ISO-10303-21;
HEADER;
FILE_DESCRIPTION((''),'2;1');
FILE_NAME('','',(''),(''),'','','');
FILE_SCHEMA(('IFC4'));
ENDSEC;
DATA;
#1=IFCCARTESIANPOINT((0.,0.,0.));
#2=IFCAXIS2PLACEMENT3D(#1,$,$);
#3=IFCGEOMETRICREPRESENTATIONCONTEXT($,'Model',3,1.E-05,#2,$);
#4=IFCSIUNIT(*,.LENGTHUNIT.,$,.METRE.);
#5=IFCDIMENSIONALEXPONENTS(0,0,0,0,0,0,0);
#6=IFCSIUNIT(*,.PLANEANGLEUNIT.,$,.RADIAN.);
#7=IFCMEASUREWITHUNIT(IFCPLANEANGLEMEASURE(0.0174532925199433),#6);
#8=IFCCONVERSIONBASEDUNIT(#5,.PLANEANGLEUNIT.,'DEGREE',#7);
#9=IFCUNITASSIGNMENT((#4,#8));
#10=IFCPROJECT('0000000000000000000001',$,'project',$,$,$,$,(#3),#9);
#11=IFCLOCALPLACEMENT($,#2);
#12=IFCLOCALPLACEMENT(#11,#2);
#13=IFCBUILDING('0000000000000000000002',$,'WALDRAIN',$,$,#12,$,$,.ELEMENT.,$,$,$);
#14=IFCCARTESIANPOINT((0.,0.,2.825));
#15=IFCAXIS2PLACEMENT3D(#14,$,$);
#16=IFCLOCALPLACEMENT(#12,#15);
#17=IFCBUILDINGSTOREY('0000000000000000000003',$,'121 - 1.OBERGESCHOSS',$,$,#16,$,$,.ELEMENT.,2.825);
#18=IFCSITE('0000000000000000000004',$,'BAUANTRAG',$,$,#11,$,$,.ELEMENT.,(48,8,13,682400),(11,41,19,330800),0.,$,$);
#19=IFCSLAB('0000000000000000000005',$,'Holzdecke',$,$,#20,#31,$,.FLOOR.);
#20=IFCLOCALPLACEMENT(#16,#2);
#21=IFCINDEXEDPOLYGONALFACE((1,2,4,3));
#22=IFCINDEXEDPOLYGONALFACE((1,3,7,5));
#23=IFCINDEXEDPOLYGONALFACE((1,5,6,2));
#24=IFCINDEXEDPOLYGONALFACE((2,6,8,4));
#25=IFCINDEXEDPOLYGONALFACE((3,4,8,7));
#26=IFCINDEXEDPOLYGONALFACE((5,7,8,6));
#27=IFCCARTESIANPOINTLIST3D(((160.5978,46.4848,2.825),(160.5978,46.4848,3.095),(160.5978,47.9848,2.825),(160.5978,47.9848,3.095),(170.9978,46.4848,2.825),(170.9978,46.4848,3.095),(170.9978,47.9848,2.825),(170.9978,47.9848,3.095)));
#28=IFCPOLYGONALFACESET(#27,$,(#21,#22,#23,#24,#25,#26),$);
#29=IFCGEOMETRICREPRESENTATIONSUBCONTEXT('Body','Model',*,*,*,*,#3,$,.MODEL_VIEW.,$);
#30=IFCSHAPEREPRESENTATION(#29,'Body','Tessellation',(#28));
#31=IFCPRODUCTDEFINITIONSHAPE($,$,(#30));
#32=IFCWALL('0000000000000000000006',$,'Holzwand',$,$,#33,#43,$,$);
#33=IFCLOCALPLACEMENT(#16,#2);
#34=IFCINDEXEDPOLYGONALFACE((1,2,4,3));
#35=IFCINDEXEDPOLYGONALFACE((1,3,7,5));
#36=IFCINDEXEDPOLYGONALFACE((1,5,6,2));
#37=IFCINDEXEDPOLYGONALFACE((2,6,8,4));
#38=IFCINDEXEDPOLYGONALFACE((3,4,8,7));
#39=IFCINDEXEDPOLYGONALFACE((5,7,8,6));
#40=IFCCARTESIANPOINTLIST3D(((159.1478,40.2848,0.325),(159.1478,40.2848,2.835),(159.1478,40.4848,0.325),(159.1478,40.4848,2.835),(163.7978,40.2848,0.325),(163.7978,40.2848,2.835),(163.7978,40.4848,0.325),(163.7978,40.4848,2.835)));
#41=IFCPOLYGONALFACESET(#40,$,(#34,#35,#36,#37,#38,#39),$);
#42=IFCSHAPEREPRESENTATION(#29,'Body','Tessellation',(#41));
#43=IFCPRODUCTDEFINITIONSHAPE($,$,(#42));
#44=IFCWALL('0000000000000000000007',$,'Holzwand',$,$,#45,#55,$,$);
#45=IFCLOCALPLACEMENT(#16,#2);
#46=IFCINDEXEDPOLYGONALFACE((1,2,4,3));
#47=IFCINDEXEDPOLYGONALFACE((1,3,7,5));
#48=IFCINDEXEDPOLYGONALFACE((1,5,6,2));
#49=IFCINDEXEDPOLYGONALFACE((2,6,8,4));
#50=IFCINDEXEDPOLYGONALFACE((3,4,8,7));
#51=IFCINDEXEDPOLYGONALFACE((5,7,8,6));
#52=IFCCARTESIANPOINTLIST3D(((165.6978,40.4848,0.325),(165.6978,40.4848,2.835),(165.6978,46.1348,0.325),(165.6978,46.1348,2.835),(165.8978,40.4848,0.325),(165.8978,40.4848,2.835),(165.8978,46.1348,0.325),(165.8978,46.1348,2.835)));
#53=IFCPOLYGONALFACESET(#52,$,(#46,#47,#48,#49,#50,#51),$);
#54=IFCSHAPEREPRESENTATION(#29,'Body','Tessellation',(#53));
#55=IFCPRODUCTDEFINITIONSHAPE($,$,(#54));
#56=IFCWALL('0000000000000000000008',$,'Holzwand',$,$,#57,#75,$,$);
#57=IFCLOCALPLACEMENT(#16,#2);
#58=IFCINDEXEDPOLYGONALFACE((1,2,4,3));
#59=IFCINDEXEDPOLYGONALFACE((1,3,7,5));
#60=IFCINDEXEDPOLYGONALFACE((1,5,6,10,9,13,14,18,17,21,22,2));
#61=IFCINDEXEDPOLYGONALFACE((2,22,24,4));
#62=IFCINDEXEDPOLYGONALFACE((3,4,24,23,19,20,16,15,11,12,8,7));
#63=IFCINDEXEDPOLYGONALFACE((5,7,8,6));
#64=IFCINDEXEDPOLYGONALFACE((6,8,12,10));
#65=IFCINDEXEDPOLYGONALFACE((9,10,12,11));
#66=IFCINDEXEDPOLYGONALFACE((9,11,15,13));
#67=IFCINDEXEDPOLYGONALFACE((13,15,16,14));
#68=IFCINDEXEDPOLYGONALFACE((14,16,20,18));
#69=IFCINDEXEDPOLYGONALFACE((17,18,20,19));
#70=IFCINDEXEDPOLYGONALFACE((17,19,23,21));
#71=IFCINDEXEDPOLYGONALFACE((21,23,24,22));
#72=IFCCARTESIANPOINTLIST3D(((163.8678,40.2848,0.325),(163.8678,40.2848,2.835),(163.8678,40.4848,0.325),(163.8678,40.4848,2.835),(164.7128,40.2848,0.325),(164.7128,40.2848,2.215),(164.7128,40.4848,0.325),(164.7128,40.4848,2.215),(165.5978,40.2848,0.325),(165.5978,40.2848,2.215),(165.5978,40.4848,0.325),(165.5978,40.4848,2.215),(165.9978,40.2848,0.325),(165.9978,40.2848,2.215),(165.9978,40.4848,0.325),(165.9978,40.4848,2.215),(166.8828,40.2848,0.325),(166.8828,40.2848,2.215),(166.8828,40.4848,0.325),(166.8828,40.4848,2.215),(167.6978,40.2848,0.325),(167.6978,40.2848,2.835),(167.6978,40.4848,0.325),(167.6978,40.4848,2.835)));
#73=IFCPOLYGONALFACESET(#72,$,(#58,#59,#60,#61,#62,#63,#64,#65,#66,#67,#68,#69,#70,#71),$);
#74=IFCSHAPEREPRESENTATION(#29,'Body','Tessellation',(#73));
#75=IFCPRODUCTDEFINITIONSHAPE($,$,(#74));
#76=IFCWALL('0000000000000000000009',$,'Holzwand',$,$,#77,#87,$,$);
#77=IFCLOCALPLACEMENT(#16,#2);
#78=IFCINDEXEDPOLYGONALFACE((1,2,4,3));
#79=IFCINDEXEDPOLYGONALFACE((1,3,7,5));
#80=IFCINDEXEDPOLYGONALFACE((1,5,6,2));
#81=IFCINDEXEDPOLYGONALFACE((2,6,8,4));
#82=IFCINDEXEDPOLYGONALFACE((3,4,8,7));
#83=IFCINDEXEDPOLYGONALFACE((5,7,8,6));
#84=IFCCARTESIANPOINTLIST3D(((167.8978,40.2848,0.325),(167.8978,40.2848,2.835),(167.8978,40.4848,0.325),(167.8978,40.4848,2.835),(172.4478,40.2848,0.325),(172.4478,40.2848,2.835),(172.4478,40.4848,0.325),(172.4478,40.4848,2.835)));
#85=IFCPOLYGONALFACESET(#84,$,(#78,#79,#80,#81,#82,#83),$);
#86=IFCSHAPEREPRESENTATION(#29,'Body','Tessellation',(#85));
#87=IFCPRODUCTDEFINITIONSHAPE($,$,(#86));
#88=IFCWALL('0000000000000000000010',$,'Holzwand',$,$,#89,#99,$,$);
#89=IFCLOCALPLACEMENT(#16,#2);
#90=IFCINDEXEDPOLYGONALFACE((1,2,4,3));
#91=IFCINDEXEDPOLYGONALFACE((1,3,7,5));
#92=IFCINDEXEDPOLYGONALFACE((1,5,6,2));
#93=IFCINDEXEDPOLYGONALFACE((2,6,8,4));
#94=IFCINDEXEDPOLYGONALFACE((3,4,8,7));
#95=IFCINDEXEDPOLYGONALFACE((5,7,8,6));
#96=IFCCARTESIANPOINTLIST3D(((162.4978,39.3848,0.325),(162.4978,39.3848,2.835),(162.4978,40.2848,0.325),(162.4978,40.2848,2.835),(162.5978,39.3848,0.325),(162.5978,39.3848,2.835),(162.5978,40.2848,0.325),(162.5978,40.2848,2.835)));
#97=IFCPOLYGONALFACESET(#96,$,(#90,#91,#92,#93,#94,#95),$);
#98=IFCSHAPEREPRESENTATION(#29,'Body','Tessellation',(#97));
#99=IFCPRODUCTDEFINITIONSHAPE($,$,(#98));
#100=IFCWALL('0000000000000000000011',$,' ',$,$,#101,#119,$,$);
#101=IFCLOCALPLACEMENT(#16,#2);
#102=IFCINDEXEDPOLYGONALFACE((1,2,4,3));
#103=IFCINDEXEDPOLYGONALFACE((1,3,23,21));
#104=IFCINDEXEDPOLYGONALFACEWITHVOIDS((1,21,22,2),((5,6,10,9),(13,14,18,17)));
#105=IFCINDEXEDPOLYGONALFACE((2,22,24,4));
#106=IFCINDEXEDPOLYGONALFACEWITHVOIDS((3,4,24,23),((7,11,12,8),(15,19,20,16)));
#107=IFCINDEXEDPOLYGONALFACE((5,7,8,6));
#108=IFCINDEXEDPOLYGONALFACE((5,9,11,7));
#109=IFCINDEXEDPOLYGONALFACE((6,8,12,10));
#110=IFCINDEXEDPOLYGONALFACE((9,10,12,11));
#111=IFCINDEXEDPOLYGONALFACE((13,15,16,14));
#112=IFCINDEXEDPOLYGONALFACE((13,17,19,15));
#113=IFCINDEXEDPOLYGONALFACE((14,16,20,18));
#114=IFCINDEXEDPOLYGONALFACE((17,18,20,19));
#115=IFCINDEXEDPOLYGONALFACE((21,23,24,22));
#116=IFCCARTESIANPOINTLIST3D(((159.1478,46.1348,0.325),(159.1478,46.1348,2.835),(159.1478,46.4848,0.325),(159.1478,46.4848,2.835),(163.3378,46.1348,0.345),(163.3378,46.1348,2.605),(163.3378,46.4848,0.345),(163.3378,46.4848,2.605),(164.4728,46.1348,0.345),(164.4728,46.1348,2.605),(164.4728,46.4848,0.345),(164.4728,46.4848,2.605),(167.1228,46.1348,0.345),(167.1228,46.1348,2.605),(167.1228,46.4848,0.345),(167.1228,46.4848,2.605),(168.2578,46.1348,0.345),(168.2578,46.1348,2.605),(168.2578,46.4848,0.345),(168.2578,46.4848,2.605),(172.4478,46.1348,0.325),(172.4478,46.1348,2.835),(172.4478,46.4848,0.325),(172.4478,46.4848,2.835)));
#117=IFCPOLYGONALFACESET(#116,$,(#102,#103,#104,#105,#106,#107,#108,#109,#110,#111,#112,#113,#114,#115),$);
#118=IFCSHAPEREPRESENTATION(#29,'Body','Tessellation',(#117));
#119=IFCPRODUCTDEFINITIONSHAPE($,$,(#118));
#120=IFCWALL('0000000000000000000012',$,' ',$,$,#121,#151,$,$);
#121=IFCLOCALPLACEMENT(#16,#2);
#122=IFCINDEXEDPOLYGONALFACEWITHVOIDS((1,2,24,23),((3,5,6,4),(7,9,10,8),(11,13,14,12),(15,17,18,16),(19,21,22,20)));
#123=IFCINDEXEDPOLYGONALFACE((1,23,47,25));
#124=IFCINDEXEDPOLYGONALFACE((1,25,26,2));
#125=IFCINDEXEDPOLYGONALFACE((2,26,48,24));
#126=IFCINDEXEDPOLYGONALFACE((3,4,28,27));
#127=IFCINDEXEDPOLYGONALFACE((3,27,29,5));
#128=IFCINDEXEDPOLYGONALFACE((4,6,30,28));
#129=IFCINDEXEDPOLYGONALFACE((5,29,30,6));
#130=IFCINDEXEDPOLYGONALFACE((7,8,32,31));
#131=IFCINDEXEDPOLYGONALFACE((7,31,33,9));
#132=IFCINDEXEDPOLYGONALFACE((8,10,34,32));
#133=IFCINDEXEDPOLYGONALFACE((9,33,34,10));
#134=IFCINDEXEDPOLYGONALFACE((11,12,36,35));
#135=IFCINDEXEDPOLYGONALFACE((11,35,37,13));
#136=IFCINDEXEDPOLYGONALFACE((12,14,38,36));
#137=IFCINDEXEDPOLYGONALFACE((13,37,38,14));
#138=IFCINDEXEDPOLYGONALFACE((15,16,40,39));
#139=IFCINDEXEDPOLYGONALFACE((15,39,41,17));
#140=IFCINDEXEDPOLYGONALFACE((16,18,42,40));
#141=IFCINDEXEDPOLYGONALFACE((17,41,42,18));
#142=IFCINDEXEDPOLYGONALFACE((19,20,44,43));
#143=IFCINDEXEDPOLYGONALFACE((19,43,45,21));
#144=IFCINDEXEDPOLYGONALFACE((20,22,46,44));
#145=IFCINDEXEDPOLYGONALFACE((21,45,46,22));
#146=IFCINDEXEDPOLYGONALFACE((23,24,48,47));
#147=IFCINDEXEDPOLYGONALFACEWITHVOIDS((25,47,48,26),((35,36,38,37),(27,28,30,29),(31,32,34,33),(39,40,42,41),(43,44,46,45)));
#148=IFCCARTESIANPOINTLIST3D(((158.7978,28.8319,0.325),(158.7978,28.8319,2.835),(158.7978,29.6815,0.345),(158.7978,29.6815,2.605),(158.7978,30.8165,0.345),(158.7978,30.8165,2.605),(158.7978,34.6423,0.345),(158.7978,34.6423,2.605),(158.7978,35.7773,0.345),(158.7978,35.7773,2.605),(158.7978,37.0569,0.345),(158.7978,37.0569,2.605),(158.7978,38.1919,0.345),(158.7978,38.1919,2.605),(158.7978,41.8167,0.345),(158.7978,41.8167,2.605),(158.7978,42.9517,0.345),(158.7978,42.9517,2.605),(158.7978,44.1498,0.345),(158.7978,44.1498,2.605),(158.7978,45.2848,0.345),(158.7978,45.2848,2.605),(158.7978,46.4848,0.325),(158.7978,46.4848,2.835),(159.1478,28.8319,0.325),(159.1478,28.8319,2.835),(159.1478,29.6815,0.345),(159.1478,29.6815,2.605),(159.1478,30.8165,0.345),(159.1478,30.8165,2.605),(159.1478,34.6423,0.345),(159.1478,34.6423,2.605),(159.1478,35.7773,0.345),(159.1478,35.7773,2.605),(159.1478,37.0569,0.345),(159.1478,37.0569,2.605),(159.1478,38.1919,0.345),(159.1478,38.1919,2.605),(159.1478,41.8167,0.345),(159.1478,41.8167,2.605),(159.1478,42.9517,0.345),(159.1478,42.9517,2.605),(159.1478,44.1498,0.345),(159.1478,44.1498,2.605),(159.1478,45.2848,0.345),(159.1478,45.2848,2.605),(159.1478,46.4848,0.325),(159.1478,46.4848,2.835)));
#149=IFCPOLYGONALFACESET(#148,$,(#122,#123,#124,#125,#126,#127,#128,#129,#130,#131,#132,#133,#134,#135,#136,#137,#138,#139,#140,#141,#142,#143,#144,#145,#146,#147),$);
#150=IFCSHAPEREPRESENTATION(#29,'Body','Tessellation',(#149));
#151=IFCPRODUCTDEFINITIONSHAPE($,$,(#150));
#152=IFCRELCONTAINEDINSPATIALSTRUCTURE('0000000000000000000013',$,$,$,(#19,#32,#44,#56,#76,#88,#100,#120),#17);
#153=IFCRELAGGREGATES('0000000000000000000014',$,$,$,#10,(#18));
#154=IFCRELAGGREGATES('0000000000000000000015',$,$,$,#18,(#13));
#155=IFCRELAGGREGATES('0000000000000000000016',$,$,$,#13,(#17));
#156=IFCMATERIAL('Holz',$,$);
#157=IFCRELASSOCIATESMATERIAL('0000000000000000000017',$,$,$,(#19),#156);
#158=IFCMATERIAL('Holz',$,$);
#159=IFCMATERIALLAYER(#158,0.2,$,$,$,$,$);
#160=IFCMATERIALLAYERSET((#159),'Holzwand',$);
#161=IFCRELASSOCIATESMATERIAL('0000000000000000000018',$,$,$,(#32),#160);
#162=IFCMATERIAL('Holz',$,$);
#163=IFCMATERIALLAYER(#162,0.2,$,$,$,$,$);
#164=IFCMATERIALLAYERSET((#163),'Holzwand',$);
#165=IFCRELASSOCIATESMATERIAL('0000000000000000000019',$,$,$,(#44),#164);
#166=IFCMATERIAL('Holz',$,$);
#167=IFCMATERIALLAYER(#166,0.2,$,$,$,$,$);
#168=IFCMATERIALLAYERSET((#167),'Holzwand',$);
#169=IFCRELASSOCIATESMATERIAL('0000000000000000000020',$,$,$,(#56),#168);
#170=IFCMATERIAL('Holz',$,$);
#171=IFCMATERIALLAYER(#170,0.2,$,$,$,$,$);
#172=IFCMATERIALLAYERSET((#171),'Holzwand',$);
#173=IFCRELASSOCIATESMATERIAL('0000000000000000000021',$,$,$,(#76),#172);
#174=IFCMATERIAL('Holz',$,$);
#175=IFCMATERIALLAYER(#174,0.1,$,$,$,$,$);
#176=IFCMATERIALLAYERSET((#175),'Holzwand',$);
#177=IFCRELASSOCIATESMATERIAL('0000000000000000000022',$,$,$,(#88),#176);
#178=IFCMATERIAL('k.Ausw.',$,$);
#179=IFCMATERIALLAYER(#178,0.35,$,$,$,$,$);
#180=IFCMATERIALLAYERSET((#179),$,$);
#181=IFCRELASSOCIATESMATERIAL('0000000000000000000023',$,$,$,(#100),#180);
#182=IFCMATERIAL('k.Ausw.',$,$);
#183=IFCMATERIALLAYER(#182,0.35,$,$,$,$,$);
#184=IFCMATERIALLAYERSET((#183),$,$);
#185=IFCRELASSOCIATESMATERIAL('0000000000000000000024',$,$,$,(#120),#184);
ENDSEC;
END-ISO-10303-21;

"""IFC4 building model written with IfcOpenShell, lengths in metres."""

from ifc_helpers import new_model, entity, si_unit, converted_unit, frame, frame_2d, origin, origin_with_axes, place, context, subcontext, project, spatial, polyline, rectangle, outline, extrude, material, layer, layer_set, layer_usage, element, save


model = new_model("IFC4")

# Units and contexts
model_context = context("Model", 3, precision=1e-05, world=origin())
body_context = subcontext(model_context, "Body", "Model", "MODEL_VIEW")
ifc_project = project(units=[si_unit("LENGTHUNIT", "METRE"), converted_unit("PLANEANGLEUNIT", "DEGREE", entity("IfcPlaneAngleMeasure", 0.0174532925199433), si_unit("PLANEANGLEUNIT", "RADIAN"), dimensions=[0, 0, 0, 0, 0, 0, 0])], contexts=[model_context])

# Site, building, storey
site_placement = place(None, origin())
site = spatial("IfcSite", under=ifc_project, at=site_placement, Name="BAUANTRAG", CompositionType="ELEMENT", RefLatitude=(48, 8, 13, 682400), RefLongitude=(11, 41, 19, 330800), RefElevation=0.0)
building_placement = place(site_placement, origin())
building = spatial("IfcBuilding", under=site, at=building_placement, Name="WALDRAIN", CompositionType="ELEMENT")
storey_placement = place(building_placement, frame((0.0, 0.0, 2.825)))
storey = spatial("IfcBuildingStorey", under=building, at=storey_placement, Name="121 - 1.OBERGESCHOSS", CompositionType="ELEMENT", Elevation=2.825)

# Slab
ifc_material_1 = material(Name="Holz")
slab_placement = place(storey_placement, frame((160.5978, 46.4848, 2.825)))
element("IfcSlab", 1, at=slab_placement, inside=storey, material=ifc_material_1, Name="Holzdecke", PredefinedType="FLOOR", context=body_context, shape_type="SweptSolid", body=[
    extrude(rectangle(XDim=10.4, YDim=1.5, at=frame_2d((5.2, 0.75), x_axis=(1.0, 0.0))), origin_with_axes(), (0.0, 0.0, 1.0), 0.27),
])

# Walls
ifc_material_2 = material(Name="Holz")
ifc_layer_1 = layer(ifc_material_2, 0.2)
ifc_layer_set_1 = layer_set([ifc_layer_1], Name="Holzwand")
ifc_layer_usage_1 = layer_usage(ifc_layer_set_1, "AXIS2", "POSITIVE", 0.0)
wall_1_placement = place(storey_placement, frame((163.7978, 40.4848, 0.325), z_axis=(0.0, 0.0, 1.0), x_axis=(-1.0, 0.0, 0.0)))
element("IfcWall", 2, at=wall_1_placement, inside=storey, material=ifc_layer_usage_1, Name="Holzwand", context=body_context, shape_type="SweptSolid", body=[
    extrude(rectangle(XDim=4.65, YDim=0.2, at=frame_2d((2.325, 0.1), x_axis=(1.0, 0.0))), origin_with_axes(), (0.0, 0.0, 1.0), 2.51),
])
ifc_material_3 = material(Name="Holz")
ifc_layer_2 = layer(ifc_material_3, 0.2)
ifc_layer_set_2 = layer_set([ifc_layer_2], Name="Holzwand")
ifc_layer_usage_2 = layer_usage(ifc_layer_set_2, "AXIS2", "POSITIVE", 0.0)
wall_2_placement = place(storey_placement, frame((165.6978, 46.1348, 0.325), z_axis=(0.0, 0.0, 1.0), x_axis=(0.0, -1.0, 0.0)))
element("IfcWall", 3, at=wall_2_placement, inside=storey, material=ifc_layer_usage_2, Name="Holzwand", context=body_context, shape_type="SweptSolid", body=[
    extrude(rectangle(XDim=5.65, YDim=0.2, at=frame_2d((2.825, 0.1), x_axis=(1.0, 0.0))), origin_with_axes(), (0.0, 0.0, 1.0), 2.51),
])

# Wall, openings
ifc_material_4 = material(Name="Holz")
ifc_layer_3 = layer(ifc_material_4, 0.2)
ifc_layer_set_3 = layer_set([ifc_layer_3], Name="Holzwand")
ifc_layer_usage_3 = layer_usage(ifc_layer_set_3, "AXIS2", "POSITIVE", 0.0)
wall_3_placement = place(storey_placement, frame((167.6978, 40.4848, 0.325), z_axis=(0.0, 0.0, 1.0), x_axis=(-1.0, 0.0, 0.0)))
wall_3 = element("IfcWall", 4, at=wall_3_placement, inside=storey, material=ifc_layer_usage_3, Name="Holzwand", context=body_context, shape_type="SweptSolid", body=[
    extrude(rectangle(XDim=3.83, YDim=0.2, at=frame_2d((1.915, 0.1), x_axis=(1.0, 0.0))), origin_with_axes(), (0.0, 0.0, 1.0), 2.51),
])
opening_1_placement = place(wall_3_placement, frame((0.815, 0.0, -0.12), z_axis=(0.0, 1.0, 0.0), x_axis=(0.0, 0.0, 1.0)))
element("IfcOpeningElement", 5, at=opening_1_placement, cuts=wall_3, ObjectType="Opening", context=body_context, shape_type="SweptSolid", body=[
    extrude(outline(polyline([(0.0, 0.885), (2.01, 0.885), (2.01, 0.0), (0.0, 0.0), (0.0, 0.885)])), origin_with_axes(), (0.0, 0.0, 1.0), 0.2),
])
opening_2_placement = place(wall_3_placement, frame((2.1, 0.0, -0.12), z_axis=(0.0, 1.0, 0.0), x_axis=(0.0, 0.0, 1.0)))
element("IfcOpeningElement", 6, at=opening_2_placement, cuts=wall_3, ObjectType="Opening", context=body_context, shape_type="SweptSolid", body=[
    extrude(outline(polyline([(0.0, 0.885), (2.01, 0.885), (2.01, 0.0), (0.0, 0.0), (0.0, 0.885)])), origin_with_axes(), (0.0, 0.0, 1.0), 0.2),
])

# Walls
ifc_material_5 = material(Name="Holz")
ifc_layer_4 = layer(ifc_material_5, 0.2)
ifc_layer_set_4 = layer_set([ifc_layer_4], Name="Holzwand")
ifc_layer_usage_4 = layer_usage(ifc_layer_set_4, "AXIS2", "POSITIVE", 0.0)
wall_4_placement = place(storey_placement, frame((172.4478, 40.4848, 0.325), z_axis=(0.0, 0.0, 1.0), x_axis=(-1.0, 0.0, 0.0)))
element("IfcWall", 7, at=wall_4_placement, inside=storey, material=ifc_layer_usage_4, Name="Holzwand", context=body_context, shape_type="SweptSolid", body=[
    extrude(rectangle(XDim=4.55, YDim=0.2, at=frame_2d((2.275, 0.1), x_axis=(1.0, 0.0))), origin_with_axes(), (0.0, 0.0, 1.0), 2.51),
])
ifc_material_6 = material(Name="Holz")
ifc_layer_5 = layer(ifc_material_6, 0.1)
ifc_layer_set_5 = layer_set([ifc_layer_5], Name="Holzwand")
ifc_layer_usage_5 = layer_usage(ifc_layer_set_5, "AXIS2", "POSITIVE", 0.0)
wall_5_placement = place(storey_placement, frame((162.4978, 40.2848, 0.325), z_axis=(0.0, 0.0, 1.0), x_axis=(0.0, -1.0, 0.0)))
element("IfcWall", 8, at=wall_5_placement, inside=storey, material=ifc_layer_usage_5, Name="Holzwand", context=body_context, shape_type="SweptSolid", body=[
    extrude(rectangle(XDim=0.9, YDim=0.1, at=frame_2d((0.45, 0.05), x_axis=(1.0, 0.0))), origin_with_axes(), (0.0, 0.0, 1.0), 2.51),
])

# Walls, openings
ifc_material_7 = material(Name="k.Ausw.")
ifc_layer_6 = layer(ifc_material_7, 0.35)
ifc_layer_set_6 = layer_set([ifc_layer_6])
ifc_layer_usage_6 = layer_usage(ifc_layer_set_6, "AXIS2", "POSITIVE", 0.0)
wall_6_placement = place(storey_placement, frame((172.4478, 46.4848, 0.325), z_axis=(0.0, 0.0, 1.0), x_axis=(-1.0, 0.0, 0.0)))
wall_6 = element("IfcWall", 9, at=wall_6_placement, inside=storey, material=ifc_layer_usage_6, Name=" ", context=body_context, shape_type="SweptSolid", body=[
    extrude(rectangle(XDim=13.3, YDim=0.35, at=frame_2d((6.65, 0.175), x_axis=(1.0, 0.0))), origin_with_axes(), (0.0, 0.0, 1.0), 2.51),
])
opening_3_placement = place(wall_6_placement, frame((9.11, 0.35, 0.02), z_axis=(0.0, -1.0, 0.0), x_axis=(0.0, 0.0, 1.0)))
element("IfcOpeningElement", 10, at=opening_3_placement, cuts=wall_6, ObjectType="Opening", context=body_context, shape_type="SweptSolid", body=[
    extrude(outline(polyline([(0.0, 1.135), (2.26, 1.135), (2.26, 0.0), (0.0, 0.0), (0.0, 1.135)])), origin_with_axes(), (0.0, 0.0, 1.0), 0.35),
])
opening_4_placement = place(wall_6_placement, frame((5.325, 0.35, 0.02), z_axis=(0.0, -1.0, 0.0), x_axis=(0.0, 0.0, 1.0)))
element("IfcOpeningElement", 11, at=opening_4_placement, cuts=wall_6, ObjectType="Opening", context=body_context, shape_type="SweptSolid", body=[
    extrude(outline(polyline([(0.0, 1.135), (2.26, 1.135), (2.26, 0.0), (0.0, 0.0), (0.0, 1.135)])), origin_with_axes(), (0.0, 0.0, 1.0), 0.35),
])
ifc_material_8 = material(Name="k.Ausw.")
ifc_layer_7 = layer(ifc_material_8, 0.35)
ifc_layer_set_7 = layer_set([ifc_layer_7])
ifc_layer_usage_7 = layer_usage(ifc_layer_set_7, "AXIS2", "POSITIVE", 0.0)
wall_7_placement = place(storey_placement, frame((158.7978, 46.4848, 0.325), z_axis=(0.0, 0.0, 1.0), x_axis=(0.0, -1.0, 0.0)))
wall_7 = element("IfcWall", 12, at=wall_7_placement, inside=storey, material=ifc_layer_usage_7, Name=" ", context=body_context, shape_type="SweptSolid", body=[
    extrude(rectangle(XDim=17.6529, YDim=0.35, at=frame_2d((8.8264, 0.175), x_axis=(1.0, 0.0))), origin_with_axes(), (0.0, 0.0, 1.0), 2.51),
])
opening_5_placement = place(wall_7_placement, frame((11.8425, 0.35, 0.02), z_axis=(0.0, -1.0, 0.0), x_axis=(0.0, 0.0, 1.0)))
element("IfcOpeningElement", 13, at=opening_5_placement, cuts=wall_7, ObjectType="Opening", context=body_context, shape_type="SweptSolid", body=[
    extrude(outline(polyline([(0.0, 1.135), (2.26, 1.135), (2.26, 0.0), (0.0, 0.0), (0.0, 1.135)])), origin_with_axes(), (0.0, 0.0, 1.0), 0.35),
])
opening_6_placement = place(wall_7_placement, frame((9.4279, 0.35, 0.02), z_axis=(0.0, -1.0, 0.0), x_axis=(0.0, 0.0, 1.0)))
element("IfcOpeningElement", 14, at=opening_6_placement, cuts=wall_7, ObjectType="Opening", context=body_context, shape_type="SweptSolid", body=[
    extrude(outline(polyline([(0.0, 1.135), (2.26, 1.135), (2.26, 0.0), (0.0, 0.0), (0.0, 1.135)])), origin_with_axes(), (0.0, 0.0, 1.0), 0.35),
])
opening_7_placement = place(wall_7_placement, frame((16.8033, 0.35, 0.02), z_axis=(0.0, -1.0, 0.0), x_axis=(0.0, 0.0, 1.0)))
element("IfcOpeningElement", 15, at=opening_7_placement, cuts=wall_7, ObjectType="Opening", context=body_context, shape_type="SweptSolid", body=[
    extrude(outline(polyline([(0.0, 1.135), (2.26, 1.135), (2.26, 0.0), (0.0, 0.0), (0.0, 1.135)])), origin_with_axes(), (0.0, 0.0, 1.0), 0.35),
])
opening_8_placement = place(wall_7_placement, frame((4.6681, 0.35, 0.02), z_axis=(0.0, -1.0, 0.0), x_axis=(0.0, 0.0, 1.0)))
element("IfcOpeningElement", 16, at=opening_8_placement, cuts=wall_7, ObjectType="Opening", context=body_context, shape_type="SweptSolid", body=[
    extrude(outline(polyline([(0.0, 1.135), (2.26, 1.135), (2.26, 0.0), (0.0, 0.0), (0.0, 1.135)])), origin_with_axes(), (0.0, 0.0, 1.0), 0.35),
])
opening_9_placement = place(wall_7_placement, frame((2.335, 0.35, 0.02), z_axis=(0.0, -1.0, 0.0), x_axis=(0.0, 0.0, 1.0)))
element("IfcOpeningElement", 17, at=opening_9_placement, cuts=wall_7, ObjectType="Opening", context=body_context, shape_type="SweptSolid", body=[
    extrude(outline(polyline([(0.0, 1.135), (2.26, 1.135), (2.26, 0.0), (0.0, 0.0), (0.0, 1.135)])), origin_with_axes(), (0.0, 0.0, 1.0), 0.35),
])

save(model, "model.ifc")
